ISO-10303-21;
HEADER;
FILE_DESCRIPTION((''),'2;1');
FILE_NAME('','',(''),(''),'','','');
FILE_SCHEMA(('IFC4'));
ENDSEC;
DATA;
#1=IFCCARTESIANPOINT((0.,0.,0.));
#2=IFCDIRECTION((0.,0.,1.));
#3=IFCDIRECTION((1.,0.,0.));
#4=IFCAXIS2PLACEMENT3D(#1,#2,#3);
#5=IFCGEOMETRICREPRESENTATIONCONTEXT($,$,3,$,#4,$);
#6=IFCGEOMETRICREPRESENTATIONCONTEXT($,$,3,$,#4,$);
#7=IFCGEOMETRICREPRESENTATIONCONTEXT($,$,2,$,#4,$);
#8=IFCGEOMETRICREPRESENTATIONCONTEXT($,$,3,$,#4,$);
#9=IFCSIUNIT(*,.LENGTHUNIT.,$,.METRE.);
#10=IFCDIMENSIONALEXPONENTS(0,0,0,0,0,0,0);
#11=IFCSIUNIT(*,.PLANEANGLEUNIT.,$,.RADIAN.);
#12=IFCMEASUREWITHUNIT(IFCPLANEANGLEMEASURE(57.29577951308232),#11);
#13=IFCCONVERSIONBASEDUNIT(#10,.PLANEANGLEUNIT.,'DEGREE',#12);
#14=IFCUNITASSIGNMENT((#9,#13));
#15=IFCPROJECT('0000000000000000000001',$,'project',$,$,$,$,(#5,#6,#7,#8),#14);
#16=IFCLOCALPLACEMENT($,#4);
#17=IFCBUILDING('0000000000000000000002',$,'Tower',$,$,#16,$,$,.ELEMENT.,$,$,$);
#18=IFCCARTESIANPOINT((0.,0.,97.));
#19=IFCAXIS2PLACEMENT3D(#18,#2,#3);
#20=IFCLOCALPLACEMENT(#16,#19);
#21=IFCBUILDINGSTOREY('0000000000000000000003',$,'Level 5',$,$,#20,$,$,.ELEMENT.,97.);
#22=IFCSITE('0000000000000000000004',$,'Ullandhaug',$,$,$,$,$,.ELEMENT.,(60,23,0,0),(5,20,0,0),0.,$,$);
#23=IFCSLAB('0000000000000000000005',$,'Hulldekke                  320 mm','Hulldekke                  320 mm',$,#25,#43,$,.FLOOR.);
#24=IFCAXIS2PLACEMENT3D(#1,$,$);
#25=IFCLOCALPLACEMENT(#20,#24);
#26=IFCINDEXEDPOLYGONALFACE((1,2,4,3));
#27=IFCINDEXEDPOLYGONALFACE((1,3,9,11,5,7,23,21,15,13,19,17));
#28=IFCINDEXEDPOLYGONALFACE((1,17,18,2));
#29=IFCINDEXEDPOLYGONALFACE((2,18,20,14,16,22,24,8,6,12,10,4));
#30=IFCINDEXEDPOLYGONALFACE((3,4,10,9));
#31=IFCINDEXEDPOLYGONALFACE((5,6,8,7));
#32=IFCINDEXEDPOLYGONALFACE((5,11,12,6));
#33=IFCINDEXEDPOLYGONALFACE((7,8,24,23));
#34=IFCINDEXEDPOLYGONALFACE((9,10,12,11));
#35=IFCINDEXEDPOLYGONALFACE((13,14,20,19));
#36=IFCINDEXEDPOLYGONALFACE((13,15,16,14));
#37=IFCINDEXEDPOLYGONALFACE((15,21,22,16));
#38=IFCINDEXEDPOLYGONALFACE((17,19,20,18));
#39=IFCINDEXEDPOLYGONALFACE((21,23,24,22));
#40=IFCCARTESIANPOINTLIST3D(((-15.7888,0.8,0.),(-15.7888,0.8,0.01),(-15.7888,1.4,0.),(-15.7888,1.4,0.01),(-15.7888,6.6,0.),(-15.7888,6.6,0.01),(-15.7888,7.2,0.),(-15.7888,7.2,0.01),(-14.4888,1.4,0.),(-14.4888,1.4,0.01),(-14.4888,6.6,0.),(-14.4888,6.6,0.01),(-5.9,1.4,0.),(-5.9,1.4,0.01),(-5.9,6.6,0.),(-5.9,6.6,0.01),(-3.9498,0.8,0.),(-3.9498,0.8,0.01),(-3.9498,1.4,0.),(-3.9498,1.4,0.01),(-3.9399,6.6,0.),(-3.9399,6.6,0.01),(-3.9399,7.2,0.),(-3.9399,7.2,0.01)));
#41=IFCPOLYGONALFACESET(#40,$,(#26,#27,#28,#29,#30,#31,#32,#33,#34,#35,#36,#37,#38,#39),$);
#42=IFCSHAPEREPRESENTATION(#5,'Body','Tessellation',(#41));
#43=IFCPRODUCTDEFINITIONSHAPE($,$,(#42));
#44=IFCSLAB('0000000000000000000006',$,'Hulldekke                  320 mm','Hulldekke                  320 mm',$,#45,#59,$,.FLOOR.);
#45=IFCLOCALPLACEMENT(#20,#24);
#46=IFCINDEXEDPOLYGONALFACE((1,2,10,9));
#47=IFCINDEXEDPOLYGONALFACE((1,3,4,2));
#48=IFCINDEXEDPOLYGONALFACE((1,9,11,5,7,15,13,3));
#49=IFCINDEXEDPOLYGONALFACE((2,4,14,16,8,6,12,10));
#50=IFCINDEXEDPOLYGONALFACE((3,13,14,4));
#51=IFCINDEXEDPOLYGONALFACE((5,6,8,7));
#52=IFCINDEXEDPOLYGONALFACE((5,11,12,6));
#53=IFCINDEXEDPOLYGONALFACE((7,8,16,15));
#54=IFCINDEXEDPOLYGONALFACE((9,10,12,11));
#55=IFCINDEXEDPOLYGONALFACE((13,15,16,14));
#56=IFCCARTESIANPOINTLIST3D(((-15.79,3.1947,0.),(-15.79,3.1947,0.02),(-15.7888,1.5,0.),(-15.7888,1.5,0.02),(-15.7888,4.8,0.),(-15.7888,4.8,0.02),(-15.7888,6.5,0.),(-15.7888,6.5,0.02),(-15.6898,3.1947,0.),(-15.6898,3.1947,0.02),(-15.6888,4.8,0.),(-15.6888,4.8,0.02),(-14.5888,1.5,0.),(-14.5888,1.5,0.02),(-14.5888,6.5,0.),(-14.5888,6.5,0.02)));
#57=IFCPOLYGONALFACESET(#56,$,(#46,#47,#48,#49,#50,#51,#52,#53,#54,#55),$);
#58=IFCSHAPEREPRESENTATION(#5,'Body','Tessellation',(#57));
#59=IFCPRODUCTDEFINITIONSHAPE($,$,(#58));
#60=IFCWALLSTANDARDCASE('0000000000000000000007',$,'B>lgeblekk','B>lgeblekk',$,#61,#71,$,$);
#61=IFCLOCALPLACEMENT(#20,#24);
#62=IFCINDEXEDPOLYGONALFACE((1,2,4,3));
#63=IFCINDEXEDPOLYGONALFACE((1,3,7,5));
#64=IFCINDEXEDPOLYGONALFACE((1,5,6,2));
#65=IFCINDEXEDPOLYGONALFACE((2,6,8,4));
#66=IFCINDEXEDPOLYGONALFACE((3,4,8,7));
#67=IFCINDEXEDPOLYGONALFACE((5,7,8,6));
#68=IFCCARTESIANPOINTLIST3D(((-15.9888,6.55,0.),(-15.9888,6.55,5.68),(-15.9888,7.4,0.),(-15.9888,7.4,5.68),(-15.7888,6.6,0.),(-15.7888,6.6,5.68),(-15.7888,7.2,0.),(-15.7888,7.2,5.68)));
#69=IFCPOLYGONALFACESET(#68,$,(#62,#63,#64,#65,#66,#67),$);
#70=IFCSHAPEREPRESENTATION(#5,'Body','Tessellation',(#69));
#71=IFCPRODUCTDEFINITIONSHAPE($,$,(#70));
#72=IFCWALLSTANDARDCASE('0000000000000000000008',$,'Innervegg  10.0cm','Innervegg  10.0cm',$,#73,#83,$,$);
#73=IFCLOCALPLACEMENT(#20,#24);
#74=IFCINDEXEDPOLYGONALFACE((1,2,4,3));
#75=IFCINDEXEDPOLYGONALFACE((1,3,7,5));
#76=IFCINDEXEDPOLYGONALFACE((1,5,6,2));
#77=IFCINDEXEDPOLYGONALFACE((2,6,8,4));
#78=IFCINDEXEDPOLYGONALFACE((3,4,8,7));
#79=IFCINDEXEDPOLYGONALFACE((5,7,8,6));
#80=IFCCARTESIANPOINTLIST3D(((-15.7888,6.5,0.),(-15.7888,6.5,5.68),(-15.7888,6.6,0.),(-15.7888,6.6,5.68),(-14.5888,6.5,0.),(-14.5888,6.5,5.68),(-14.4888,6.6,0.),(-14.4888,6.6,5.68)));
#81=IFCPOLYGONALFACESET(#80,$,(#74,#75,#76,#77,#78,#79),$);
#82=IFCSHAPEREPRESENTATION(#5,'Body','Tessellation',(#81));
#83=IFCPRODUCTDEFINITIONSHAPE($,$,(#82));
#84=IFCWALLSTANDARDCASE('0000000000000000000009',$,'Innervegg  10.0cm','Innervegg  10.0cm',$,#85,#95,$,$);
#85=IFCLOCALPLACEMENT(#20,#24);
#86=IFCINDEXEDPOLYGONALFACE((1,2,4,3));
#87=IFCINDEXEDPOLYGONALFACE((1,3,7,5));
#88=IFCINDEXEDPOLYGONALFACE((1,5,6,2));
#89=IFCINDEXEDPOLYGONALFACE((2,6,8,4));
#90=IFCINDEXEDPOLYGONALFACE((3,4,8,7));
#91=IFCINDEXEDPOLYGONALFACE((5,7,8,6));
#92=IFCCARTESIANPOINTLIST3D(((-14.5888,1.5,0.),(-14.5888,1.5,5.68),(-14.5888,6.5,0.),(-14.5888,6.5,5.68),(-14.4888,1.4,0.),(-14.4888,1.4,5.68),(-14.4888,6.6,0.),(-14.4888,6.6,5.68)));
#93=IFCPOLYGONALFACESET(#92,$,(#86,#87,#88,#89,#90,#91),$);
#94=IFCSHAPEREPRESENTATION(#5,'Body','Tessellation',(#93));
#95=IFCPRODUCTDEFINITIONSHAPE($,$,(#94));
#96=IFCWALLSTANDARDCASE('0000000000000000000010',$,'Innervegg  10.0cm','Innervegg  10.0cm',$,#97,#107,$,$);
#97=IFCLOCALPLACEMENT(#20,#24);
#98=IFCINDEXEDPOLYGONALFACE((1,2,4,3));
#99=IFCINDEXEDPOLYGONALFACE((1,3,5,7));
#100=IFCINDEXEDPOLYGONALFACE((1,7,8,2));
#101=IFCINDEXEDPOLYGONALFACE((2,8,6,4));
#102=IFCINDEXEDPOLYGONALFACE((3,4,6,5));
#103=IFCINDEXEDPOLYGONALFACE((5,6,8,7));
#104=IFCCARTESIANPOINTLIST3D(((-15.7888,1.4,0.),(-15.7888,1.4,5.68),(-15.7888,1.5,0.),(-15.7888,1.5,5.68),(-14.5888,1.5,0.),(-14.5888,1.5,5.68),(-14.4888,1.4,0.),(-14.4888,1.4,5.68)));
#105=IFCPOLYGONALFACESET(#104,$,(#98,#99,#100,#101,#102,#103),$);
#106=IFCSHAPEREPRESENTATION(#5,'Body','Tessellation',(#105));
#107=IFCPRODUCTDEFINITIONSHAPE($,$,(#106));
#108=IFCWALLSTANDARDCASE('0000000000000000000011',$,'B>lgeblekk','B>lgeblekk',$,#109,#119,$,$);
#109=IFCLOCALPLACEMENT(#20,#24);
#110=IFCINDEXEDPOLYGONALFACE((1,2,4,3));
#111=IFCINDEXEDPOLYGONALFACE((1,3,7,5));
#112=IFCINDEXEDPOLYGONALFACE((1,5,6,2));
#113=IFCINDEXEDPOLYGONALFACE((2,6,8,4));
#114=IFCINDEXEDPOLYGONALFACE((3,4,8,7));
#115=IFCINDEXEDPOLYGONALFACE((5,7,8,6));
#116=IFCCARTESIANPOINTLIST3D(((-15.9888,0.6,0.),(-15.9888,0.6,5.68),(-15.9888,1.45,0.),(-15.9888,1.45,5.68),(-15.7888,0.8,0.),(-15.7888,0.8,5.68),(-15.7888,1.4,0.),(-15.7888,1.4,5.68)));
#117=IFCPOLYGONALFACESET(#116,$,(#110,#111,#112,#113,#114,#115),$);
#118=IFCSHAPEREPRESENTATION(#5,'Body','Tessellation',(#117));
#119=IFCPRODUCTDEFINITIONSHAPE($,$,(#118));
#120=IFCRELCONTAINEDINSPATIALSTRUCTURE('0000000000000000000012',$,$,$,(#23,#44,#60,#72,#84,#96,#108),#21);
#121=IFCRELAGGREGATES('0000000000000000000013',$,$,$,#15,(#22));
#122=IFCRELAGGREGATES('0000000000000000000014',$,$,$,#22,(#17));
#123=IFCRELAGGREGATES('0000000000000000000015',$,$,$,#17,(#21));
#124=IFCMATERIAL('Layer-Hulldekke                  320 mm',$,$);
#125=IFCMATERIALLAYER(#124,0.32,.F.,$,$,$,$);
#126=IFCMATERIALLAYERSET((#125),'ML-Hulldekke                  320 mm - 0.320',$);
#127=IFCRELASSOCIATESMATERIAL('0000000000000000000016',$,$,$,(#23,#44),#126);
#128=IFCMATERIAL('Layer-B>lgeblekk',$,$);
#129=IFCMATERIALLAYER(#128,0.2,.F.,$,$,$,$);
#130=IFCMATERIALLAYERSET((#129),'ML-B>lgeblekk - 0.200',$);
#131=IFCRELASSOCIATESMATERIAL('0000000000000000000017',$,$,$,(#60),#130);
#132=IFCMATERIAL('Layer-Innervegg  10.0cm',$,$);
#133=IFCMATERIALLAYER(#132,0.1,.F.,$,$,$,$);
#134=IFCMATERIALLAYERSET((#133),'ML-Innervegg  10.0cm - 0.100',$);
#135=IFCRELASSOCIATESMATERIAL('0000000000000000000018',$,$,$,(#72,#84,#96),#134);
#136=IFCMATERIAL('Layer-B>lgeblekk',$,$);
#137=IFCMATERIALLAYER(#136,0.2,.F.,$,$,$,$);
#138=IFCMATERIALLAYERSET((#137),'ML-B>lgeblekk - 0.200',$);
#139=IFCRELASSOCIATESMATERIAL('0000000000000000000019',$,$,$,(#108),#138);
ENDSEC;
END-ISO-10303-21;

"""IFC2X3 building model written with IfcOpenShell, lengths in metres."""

from ifc_helpers import new_model, entity, si_unit, converted_unit, frame, origin_with_axes, place, context, project, spatial, polyline, outline, extrude, material, layer, layer_set, layer_usage, element, save


model = new_model("IFC2X3")

# Units and contexts
context_of_model_1 = context(None, 3, world=origin_with_axes())
context_of_model_2 = context(None, 3, world=origin_with_axes())
context_of_model_3 = context(None, 2, world=origin_with_axes())
context_of_model_4 = context(None, 3, world=origin_with_axes())
ifc_project = project(units=[si_unit("LENGTHUNIT", "METRE"), converted_unit("PLANEANGLEUNIT", "DEGREE", entity("IfcPlaneAngleMeasure", 57.29577951308232), si_unit("PLANEANGLEUNIT", "RADIAN"), dimensions=[0, 0, 0, 0, 0, 0, 0])], contexts=[context_of_model_1, context_of_model_2, context_of_model_3, context_of_model_4])

# Site, building, storey
site = spatial("IfcSite", under=ifc_project, Name="Ullandhaug", CompositionType="ELEMENT", RefLatitude=(60, 23, 0, 0), RefLongitude=(5, 20, 0, 0), RefElevation=0.0)
building_placement = place(None, origin_with_axes())
building = spatial("IfcBuilding", under=site, at=building_placement, Name="Tower", CompositionType="ELEMENT")
storey_placement = place(building_placement, frame((0.0, 0.0, 97.0), z_axis=(0.0, 0.0, 1.0), x_axis=(1.0, 0.0, 0.0)))
storey = spatial("IfcBuildingStorey", under=building, at=storey_placement, Name="Level 5", CompositionType="ELEMENT", Elevation=97.0)

# Slabs
ifc_material_1 = material(Name="Layer-Hulldekke                  320 mm")
ifc_layer_1 = layer(ifc_material_1, 0.32, ventilated=False)
ifc_layer_set_1 = layer_set([ifc_layer_1], Name="ML-Hulldekke                  320 mm - 0.320")
ifc_layer_usage_1 = layer_usage(ifc_layer_set_1, "AXIS2", "POSITIVE", 0.0)
slab_1_placement = place(storey_placement, frame((-3.9399, 6.6, 0.0), z_axis=(0.0, 0.0, 1.0), x_axis=(1.0, 0.0, 0.0)))
element("IfcSlab", 1, at=slab_1_placement, inside=storey, material=ifc_layer_usage_1, Name="Hulldekke                  320 mm", Description="Hulldekke                  320 mm", PredefinedType="FLOOR", context=context_of_model_1, shape_type="SweptSolid", body=[
    extrude(outline(polyline([(0.0, 0.0), (0.6, 0.0), (0.6, 11.8489), (0.0, 11.8489), (0.0, 10.5489), (-5.2, 10.5489), (-5.2, 11.8489), (-5.8, 11.8489), (-5.8, 0.0099), (-5.2, 0.0099), (-5.2, 1.9601), (0.0, 1.9601), (0.0, 0.0)])), frame((0.0, 0.0, 0.0), z_axis=(0.0, 0.0, 1.0), x_axis=(0.0, 1.0, 0.0)), (0.0, 0.0, 1.0), 0.01),
])
slab_2_placement = place(storey_placement, frame((-15.7888, 6.5, 0.0), z_axis=(0.0, 0.0, 1.0), x_axis=(1.0, 0.0, 0.0)))
element("IfcSlab", 2, at=slab_2_placement, inside=storey, material=ifc_layer_usage_1, Name="Hulldekke                  320 mm", Description="Hulldekke                  320 mm", PredefinedType="FLOOR", context=context_of_model_1, shape_type="SweptSolid", body=[
    extrude(outline(polyline([(0.0, 0.0), (1.7, 0.0), (1.7, 0.1), (3.3053, 0.099), (3.3053, -0.0011), (5.0, 0.0), (5.0, 1.2), (0.0, 1.2), (0.0, 0.0)])), frame((0.0, 0.0, 0.0), z_axis=(0.0, 0.0, 1.0), x_axis=(0.0, -1.0, 0.0)), (0.0, 0.0, 1.0), 0.02),
])

# Walls
ifc_material_2 = material(Name="Layer-B>lgeblekk")
ifc_layer_2 = layer(ifc_material_2, 0.2, ventilated=False)
ifc_layer_set_2 = layer_set([ifc_layer_2], Name="ML-B>lgeblekk - 0.200")
ifc_layer_usage_2 = layer_usage(ifc_layer_set_2, "AXIS2", "POSITIVE", 0.0)
wall_1_placement = place(storey_placement, frame((-15.9888, 7.4, 0.0), z_axis=(0.0, 0.0, 1.0), x_axis=(0.0, -1.0, 0.0)))
element("IfcWallStandardCase", 3, at=wall_1_placement, inside=storey, material=ifc_layer_usage_2, Name="B>lgeblekk", Description="B>lgeblekk", context=context_of_model_1, shape_type="SweptSolid", body=[
    extrude(outline(polyline([(0.0, 0.0), (0.85, 0.0), (0.8, 0.2), (0.2, 0.2), (0.0, 0.0)])), frame((0.0, 0.0, 0.0), z_axis=(0.0, 0.0, 1.0), x_axis=(1.0, 0.0, 0.0)), (0.0, 0.0, 1.0), 5.68),
])
ifc_material_3 = material(Name="Layer-Innervegg  10.0cm")
ifc_layer_3 = layer(ifc_material_3, 0.1, ventilated=False)
ifc_layer_set_3 = layer_set([ifc_layer_3], Name="ML-Innervegg  10.0cm - 0.100")
ifc_layer_usage_3 = layer_usage(ifc_layer_set_3, "AXIS2", "POSITIVE", 0.0)
wall_2_placement = place(storey_placement, frame((-15.7888, 6.5, 0.0), z_axis=(0.0, 0.0, 1.0), x_axis=(1.0, 0.0, 0.0)))
element("IfcWallStandardCase", 4, at=wall_2_placement, inside=storey, material=ifc_layer_usage_3, Name="Innervegg  10.0cm", Description="Innervegg  10.0cm", context=context_of_model_1, shape_type="SweptSolid", body=[
    extrude(outline(polyline([(0.0, 0.0), (1.2, 0.0), (1.3, 0.1), (0.0, 0.1), (0.0, 0.0)])), origin_with_axes(), (0.0, 0.0, 1.0), 5.68),
])
wall_3_placement = place(storey_placement, frame((-14.5888, 6.5, 0.0), z_axis=(0.0, 0.0, 1.0), x_axis=(0.0, -1.0, 0.0)))
element("IfcWallStandardCase", 5, at=wall_3_placement, inside=storey, material=ifc_layer_usage_3, Name="Innervegg  10.0cm", Description="Innervegg  10.0cm", context=context_of_model_1, shape_type="SweptSolid", body=[
    extrude(outline(polyline([(0.0, 0.0), (5.0, 0.0), (5.1, 0.1), (-0.1, 0.1), (0.0, 0.0)])), frame((0.0, 0.0, 0.0), z_axis=(0.0, 0.0, 1.0), x_axis=(1.0, 0.0, 0.0)), (0.0, 0.0, 1.0), 5.68),
])
wall_4_placement = place(storey_placement, frame((-14.5888, 1.5, 0.0), z_axis=(0.0, 0.0, 1.0), x_axis=(-1.0, 0.0, 0.0)))
element("IfcWallStandardCase", 6, at=wall_4_placement, inside=storey, material=ifc_layer_usage_3, Name="Innervegg  10.0cm", Description="Innervegg  10.0cm", context=context_of_model_1, shape_type="SweptSolid", body=[
    extrude(outline(polyline([(0.0, 0.0), (1.2, 0.0), (1.2, 0.1), (-0.1, 0.1), (0.0, 0.0)])), frame((0.0, 0.0, 0.0), z_axis=(0.0, 0.0, 1.0), x_axis=(1.0, 0.0, 0.0)), (0.0, 0.0, 1.0), 5.68),
])
ifc_material_4 = material(Name="Layer-B>lgeblekk")
ifc_layer_4 = layer(ifc_material_4, 0.2, ventilated=False)
ifc_layer_set_4 = layer_set([ifc_layer_4], Name="ML-B>lgeblekk - 0.200")
ifc_layer_usage_4 = layer_usage(ifc_layer_set_4, "AXIS2", "POSITIVE", 0.0)
wall_5_placement = place(storey_placement, frame((-15.9888, 1.45, 0.0), z_axis=(0.0, 0.0, 1.0), x_axis=(0.0, -1.0, 0.0)))
element("IfcWallStandardCase", 7, at=wall_5_placement, inside=storey, material=ifc_layer_usage_4, Name="B>lgeblekk", Description="B>lgeblekk", context=context_of_model_1, shape_type="SweptSolid", body=[
    extrude(outline(polyline([(0.0, 0.0), (0.85, 0.0), (0.65, 0.2), (0.05, 0.2), (0.0, 0.0)])), frame((0.0, 0.0, 0.0), z_axis=(0.0, 0.0, 1.0), x_axis=(1.0, 0.0, 0.0)), (0.0, 0.0, 1.0), 5.68),
])

save(model, "model.ifc")
